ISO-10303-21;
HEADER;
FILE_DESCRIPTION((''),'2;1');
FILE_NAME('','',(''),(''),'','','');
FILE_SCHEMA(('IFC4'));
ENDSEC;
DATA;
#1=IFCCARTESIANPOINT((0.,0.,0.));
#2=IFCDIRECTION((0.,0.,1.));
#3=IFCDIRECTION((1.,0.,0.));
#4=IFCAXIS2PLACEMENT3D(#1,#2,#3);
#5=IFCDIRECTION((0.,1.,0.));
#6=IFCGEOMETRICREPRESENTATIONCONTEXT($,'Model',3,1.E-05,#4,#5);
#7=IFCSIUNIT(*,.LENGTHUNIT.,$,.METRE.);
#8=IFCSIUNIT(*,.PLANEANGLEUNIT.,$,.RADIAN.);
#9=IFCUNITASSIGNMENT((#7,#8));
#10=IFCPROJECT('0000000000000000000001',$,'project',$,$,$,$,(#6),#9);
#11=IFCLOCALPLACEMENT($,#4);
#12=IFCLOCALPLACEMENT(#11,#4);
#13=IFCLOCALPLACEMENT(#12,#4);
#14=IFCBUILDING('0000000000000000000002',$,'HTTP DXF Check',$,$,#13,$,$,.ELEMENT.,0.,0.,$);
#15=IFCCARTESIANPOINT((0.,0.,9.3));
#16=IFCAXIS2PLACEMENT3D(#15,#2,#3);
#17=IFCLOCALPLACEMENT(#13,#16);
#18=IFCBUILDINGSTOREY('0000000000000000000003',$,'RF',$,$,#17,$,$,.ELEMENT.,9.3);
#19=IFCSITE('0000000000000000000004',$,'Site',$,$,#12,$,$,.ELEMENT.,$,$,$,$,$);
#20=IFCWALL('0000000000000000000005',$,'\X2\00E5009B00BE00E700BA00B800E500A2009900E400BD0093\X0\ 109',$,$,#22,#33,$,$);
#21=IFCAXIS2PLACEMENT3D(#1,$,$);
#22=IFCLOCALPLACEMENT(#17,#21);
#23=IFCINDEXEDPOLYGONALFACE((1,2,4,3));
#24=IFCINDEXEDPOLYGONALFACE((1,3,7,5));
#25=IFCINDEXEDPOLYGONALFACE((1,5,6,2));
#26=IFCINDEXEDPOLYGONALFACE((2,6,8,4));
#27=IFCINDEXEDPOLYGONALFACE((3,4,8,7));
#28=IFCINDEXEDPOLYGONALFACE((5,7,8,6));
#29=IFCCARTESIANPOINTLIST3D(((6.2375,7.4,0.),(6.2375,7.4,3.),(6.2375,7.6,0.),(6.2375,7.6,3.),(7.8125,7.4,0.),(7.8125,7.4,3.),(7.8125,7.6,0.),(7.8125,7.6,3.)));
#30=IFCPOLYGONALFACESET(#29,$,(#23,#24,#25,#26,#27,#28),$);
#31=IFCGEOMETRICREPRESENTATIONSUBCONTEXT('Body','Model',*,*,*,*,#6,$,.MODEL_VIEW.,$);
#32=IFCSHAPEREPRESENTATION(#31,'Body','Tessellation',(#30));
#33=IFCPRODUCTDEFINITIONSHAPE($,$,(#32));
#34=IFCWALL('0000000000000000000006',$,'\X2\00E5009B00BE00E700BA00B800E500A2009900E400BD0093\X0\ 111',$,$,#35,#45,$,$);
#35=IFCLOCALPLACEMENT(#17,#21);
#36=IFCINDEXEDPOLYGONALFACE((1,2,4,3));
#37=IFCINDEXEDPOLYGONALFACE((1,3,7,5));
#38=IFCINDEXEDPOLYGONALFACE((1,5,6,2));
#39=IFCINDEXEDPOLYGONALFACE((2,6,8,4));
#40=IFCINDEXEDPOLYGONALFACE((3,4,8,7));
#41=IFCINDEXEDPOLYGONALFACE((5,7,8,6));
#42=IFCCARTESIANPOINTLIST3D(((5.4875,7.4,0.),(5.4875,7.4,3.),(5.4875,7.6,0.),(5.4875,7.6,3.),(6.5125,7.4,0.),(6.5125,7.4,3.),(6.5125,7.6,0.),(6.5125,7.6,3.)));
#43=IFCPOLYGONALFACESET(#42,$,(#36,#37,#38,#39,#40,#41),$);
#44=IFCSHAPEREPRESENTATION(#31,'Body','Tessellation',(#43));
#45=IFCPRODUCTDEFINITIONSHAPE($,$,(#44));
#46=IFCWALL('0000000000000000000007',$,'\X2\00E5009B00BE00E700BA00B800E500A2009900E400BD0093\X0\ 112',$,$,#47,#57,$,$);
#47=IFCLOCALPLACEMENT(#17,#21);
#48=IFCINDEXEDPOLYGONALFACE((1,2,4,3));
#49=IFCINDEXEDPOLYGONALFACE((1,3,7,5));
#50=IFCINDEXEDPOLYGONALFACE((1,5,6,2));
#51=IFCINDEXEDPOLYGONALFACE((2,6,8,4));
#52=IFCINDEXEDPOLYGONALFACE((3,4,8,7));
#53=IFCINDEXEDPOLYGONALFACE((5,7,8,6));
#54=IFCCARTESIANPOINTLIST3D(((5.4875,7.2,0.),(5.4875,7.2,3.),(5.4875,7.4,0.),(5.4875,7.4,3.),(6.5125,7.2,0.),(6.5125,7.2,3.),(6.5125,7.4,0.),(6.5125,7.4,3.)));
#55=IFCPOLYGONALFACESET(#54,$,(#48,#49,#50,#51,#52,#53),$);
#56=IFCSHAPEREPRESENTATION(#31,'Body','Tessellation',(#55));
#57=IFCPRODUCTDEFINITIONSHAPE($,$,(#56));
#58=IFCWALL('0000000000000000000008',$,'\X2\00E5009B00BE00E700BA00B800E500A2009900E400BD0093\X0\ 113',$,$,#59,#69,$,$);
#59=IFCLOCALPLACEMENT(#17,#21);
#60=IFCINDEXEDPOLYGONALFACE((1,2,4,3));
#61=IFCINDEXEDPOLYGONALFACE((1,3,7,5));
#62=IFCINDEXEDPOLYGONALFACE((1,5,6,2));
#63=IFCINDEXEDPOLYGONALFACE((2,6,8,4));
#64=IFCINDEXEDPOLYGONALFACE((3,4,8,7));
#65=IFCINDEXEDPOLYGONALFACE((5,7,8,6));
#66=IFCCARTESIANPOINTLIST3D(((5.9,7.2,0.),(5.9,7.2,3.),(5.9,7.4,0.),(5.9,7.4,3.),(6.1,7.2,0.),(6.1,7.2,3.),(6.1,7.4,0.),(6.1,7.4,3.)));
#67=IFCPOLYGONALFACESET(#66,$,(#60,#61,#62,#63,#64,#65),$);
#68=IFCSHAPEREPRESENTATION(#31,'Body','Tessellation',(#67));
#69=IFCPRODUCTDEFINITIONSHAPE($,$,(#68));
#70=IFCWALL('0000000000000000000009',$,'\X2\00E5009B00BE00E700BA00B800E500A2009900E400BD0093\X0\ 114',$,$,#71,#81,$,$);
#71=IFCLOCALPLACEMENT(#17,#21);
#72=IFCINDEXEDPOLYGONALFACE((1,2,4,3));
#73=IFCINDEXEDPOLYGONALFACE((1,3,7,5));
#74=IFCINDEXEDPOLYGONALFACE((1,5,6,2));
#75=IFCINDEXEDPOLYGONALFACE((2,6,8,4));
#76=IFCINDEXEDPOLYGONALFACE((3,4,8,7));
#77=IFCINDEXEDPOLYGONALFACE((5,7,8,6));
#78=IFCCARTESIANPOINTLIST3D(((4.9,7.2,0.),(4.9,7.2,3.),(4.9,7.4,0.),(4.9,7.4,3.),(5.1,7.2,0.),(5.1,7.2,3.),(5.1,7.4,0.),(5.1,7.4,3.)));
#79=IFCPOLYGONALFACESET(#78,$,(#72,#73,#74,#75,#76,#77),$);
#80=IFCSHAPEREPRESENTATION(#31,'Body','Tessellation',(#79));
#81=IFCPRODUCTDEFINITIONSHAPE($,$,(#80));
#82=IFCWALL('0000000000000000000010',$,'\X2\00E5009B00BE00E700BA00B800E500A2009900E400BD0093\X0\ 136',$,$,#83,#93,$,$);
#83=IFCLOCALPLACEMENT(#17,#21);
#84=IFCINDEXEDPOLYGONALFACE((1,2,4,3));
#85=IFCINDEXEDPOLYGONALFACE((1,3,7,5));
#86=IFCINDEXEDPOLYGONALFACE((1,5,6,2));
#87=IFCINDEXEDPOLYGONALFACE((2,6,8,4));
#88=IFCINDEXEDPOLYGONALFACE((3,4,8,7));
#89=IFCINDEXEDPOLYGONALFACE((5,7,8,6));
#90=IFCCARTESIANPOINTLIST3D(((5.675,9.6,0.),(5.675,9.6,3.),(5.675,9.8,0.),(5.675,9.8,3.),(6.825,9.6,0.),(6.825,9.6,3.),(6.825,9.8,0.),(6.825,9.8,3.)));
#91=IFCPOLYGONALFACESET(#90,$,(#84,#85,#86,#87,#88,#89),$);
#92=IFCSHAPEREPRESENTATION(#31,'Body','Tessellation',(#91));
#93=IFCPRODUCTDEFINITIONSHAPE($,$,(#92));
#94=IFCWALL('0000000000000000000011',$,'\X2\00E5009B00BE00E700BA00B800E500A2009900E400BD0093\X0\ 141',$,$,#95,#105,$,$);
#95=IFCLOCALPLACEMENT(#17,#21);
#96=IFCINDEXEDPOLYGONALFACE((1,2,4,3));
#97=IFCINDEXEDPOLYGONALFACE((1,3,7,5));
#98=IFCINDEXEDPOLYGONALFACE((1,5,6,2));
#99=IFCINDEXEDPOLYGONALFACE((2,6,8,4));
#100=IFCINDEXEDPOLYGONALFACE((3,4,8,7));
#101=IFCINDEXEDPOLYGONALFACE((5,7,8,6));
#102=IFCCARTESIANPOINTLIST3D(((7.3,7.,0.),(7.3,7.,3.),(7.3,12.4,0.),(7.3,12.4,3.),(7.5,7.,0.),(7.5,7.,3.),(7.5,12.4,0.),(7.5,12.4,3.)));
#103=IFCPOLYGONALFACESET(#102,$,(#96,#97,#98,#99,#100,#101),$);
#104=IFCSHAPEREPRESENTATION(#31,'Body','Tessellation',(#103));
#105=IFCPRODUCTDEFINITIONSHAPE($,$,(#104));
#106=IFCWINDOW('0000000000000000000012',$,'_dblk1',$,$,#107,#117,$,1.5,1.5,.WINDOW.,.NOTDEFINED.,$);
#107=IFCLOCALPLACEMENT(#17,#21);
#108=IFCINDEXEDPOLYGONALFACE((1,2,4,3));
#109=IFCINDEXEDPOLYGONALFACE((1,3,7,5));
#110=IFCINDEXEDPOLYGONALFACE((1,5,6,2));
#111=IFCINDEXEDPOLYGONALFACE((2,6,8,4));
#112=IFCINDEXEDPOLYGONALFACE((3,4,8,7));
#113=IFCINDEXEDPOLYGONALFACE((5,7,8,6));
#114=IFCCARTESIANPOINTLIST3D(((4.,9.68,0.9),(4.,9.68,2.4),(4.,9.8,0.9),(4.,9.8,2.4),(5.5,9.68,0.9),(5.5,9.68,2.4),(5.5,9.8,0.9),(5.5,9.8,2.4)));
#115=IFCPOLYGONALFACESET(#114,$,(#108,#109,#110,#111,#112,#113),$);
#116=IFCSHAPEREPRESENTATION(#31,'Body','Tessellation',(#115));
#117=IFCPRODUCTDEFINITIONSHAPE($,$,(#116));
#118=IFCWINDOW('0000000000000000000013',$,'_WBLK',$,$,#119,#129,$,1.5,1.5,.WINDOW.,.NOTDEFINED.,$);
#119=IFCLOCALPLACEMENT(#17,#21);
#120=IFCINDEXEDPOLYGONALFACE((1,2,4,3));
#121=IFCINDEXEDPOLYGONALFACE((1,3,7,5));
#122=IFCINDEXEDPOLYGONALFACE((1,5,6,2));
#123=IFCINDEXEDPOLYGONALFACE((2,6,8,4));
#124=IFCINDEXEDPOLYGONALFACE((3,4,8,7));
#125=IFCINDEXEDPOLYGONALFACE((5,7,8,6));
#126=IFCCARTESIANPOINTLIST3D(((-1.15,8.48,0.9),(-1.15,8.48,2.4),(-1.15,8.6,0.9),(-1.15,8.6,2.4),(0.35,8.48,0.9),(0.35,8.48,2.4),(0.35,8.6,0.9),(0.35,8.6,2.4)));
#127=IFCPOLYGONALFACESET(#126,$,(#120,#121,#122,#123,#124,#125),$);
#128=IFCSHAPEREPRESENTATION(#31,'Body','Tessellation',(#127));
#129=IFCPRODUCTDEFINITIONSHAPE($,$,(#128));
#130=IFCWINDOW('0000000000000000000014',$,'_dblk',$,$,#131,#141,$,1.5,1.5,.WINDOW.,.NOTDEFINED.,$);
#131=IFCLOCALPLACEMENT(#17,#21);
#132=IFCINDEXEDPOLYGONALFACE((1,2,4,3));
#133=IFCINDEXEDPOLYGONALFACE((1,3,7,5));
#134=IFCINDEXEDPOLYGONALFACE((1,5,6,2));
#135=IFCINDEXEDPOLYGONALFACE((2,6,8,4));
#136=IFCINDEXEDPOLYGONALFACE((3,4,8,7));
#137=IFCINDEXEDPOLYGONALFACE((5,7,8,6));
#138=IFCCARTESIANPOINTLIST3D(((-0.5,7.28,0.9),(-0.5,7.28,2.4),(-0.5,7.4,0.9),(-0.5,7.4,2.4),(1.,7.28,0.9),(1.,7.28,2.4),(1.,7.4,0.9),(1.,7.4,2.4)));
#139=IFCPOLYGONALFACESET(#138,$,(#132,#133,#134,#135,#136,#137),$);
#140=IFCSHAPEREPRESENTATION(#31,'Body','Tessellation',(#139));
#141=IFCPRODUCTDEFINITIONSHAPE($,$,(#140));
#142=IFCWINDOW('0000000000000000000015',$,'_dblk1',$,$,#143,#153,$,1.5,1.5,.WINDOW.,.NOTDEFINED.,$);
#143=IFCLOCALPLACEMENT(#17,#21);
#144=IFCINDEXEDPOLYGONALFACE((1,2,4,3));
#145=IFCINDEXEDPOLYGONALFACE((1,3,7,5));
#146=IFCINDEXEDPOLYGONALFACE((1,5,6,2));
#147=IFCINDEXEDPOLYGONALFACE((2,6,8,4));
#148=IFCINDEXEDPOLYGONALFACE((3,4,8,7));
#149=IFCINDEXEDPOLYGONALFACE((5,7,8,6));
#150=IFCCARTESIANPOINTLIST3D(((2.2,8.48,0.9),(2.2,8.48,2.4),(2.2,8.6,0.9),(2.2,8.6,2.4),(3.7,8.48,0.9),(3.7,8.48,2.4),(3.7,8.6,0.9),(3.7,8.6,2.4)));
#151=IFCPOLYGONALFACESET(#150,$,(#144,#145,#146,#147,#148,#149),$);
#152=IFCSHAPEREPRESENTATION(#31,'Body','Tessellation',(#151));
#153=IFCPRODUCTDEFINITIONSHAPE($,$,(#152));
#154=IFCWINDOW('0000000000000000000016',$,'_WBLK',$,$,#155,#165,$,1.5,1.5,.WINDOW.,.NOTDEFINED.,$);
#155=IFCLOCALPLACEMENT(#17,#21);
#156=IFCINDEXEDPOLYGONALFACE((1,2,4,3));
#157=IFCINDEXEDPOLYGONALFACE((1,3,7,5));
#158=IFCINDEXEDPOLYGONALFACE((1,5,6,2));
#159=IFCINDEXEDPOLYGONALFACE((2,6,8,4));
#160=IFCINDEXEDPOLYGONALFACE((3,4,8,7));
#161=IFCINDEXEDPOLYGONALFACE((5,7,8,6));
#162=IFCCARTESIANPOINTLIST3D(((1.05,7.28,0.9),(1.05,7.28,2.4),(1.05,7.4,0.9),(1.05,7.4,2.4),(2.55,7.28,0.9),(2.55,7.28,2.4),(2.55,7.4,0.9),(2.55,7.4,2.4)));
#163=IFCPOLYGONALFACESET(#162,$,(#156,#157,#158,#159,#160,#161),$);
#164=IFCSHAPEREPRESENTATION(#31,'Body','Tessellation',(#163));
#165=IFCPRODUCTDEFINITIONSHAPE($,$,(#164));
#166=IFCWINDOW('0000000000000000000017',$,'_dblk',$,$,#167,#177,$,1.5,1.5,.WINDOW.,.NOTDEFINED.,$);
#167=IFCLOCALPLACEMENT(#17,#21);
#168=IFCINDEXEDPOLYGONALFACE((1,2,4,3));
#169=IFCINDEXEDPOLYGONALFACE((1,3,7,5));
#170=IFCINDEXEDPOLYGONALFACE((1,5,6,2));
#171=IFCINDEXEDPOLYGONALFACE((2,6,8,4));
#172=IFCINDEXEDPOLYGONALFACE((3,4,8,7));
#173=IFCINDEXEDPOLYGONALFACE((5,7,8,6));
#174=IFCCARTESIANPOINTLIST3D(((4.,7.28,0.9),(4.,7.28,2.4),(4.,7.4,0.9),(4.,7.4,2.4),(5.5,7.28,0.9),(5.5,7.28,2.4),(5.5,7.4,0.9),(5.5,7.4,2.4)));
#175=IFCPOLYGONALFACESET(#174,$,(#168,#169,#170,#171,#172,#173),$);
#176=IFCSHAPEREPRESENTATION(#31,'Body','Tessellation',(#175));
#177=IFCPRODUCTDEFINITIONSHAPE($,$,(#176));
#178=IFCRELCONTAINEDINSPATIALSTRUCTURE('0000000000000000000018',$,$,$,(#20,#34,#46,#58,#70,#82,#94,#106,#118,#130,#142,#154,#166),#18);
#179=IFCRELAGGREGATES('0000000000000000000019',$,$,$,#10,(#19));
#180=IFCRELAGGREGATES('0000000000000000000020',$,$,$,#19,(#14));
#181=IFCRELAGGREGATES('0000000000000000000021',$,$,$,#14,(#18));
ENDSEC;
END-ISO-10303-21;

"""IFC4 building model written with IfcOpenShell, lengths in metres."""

from ifc_helpers import new_model, si_unit, direction, frame, frame_2d, origin_with_axes, place, context, subcontext, project, spatial, rectangle, extrude, element, save


model = new_model("IFC4")

# Units and contexts
model_context = context("Model", 3, precision=1e-05, world=origin_with_axes(), true_north=direction((0.0, 1.0, 0.0)))
body_context = subcontext(model_context, "Body", "Model", "MODEL_VIEW")
ifc_project = project(units=[si_unit("LENGTHUNIT", "METRE"), si_unit("PLANEANGLEUNIT", "RADIAN")], contexts=[model_context])

# Site, building, storey
placement = place(None, origin_with_axes())
site_placement = place(placement, origin_with_axes())
site = spatial("IfcSite", under=ifc_project, at=site_placement, Name="Site", CompositionType="ELEMENT")
building_placement = place(site_placement, origin_with_axes())
building = spatial("IfcBuilding", under=site, at=building_placement, Name="HTTP DXF Check", CompositionType="ELEMENT", ElevationOfRefHeight=0.0, ElevationOfTerrain=0.0)
storey_placement = place(building_placement, frame((0.0, 0.0, 9.3), z_axis=(0.0, 0.0, 1.0), x_axis=(1.0, 0.0, 0.0)))
storey = spatial("IfcBuildingStorey", under=building, at=storey_placement, Name="RF", CompositionType="ELEMENT", Elevation=9.3)

# Walls
wall_1_placement = place(storey_placement, frame((7.025, 7.5, 0.0), z_axis=(0.0, 0.0, 1.0), x_axis=(1.0, 0.0, 0.0)))
element("IfcWall", 1, at=wall_1_placement, inside=storey, Name="å\u009b¾çº¸å¢\u0099ä½\u0093 109", context=body_context, shape_type="SweptSolid", body=[
    extrude(rectangle(XDim=1.575, YDim=0.2, at=frame_2d((0.0, 0.0), x_axis=(1.0, 0.0, 0.0))), frame((0.0, 0.0, 0.0), z_axis=(0.0, 0.0, 1.0)), (0.0, 0.0, 1.0), 3.0),
])
for number, where, z_axis, x_axis, name in (
    (2, (6.0, 7.5, 0.0), (0.0, 0.0, 1.0), (1.0, 0.0, 0.0), "å\u009b¾çº¸å¢\u0099ä½\u0093 111"),
    (3, (6.0, 7.3, 0.0), (0.0, 0.0, 1.0), (1.0, 0.0, 0.0), "å\u009b¾çº¸å¢\u0099ä½\u0093 112"),
):
    element("IfcWall", number, at=place(storey_placement, frame(where, z_axis=z_axis, x_axis=x_axis)), inside=storey, Name=name, context=body_context, shape_type="SweptSolid", body=[
        extrude(rectangle(XDim=1.025, YDim=0.2, at=frame_2d((0.0, 0.0), x_axis=(1.0, 0.0, 0.0))), frame((0.0, 0.0, 0.0), z_axis=(0.0, 0.0, 1.0)), (0.0, 0.0, 1.0), 3.0),
    ])
for number, where, z_axis, x_axis, name in (
    (4, (6.0, 7.3, 0.0), (0.0, 0.0, 1.0), (0.0, 1.0, 0.0), "å\u009b¾çº¸å¢\u0099ä½\u0093 113"),
    (5, (5.0, 7.3, 0.0), (0.0, 0.0, 1.0), (0.0, 1.0, 0.0), "å\u009b¾çº¸å¢\u0099ä½\u0093 114"),
):
    element("IfcWall", number, at=place(storey_placement, frame(where, z_axis=z_axis, x_axis=x_axis)), inside=storey, Name=name, context=body_context, shape_type="SweptSolid", body=[
        extrude(rectangle(XDim=0.2, YDim=0.2, at=frame_2d((0.0, 0.0), x_axis=(1.0, 0.0, 0.0))), frame((0.0, 0.0, 0.0), z_axis=(0.0, 0.0, 1.0)), (0.0, 0.0, 1.0), 3.0),
    ])
wall_2_placement = place(storey_placement, frame((6.25, 9.7, 0.0), z_axis=(0.0, 0.0, 1.0), x_axis=(1.0, 0.0, 0.0)))
element("IfcWall", 6, at=wall_2_placement, inside=storey, Name="å\u009b¾çº¸å¢\u0099ä½\u0093 136", context=body_context, shape_type="SweptSolid", body=[
    extrude(rectangle(XDim=1.15, YDim=0.2, at=frame_2d((0.0, 0.0), x_axis=(1.0, 0.0, 0.0))), frame((0.0, 0.0, 0.0), z_axis=(0.0, 0.0, 1.0)), (0.0, 0.0, 1.0), 3.0),
])
wall_3_placement = place(storey_placement, frame((7.4, 9.7, 0.0), z_axis=(0.0, 0.0, 1.0), x_axis=(0.0, 1.0, 0.0)))
element("IfcWall", 7, at=wall_3_placement, inside=storey, Name="å\u009b¾çº¸å¢\u0099ä½\u0093 141", context=body_context, shape_type="SweptSolid", body=[
    extrude(rectangle(XDim=5.4, YDim=0.2, at=frame_2d((0.0, 0.0), x_axis=(1.0, 0.0, 0.0))), frame((0.0, 0.0, 0.0), z_axis=(0.0, 0.0, 1.0)), (0.0, 0.0, 1.0), 3.0),
])

# Windows
for number, where, z_axis, x_axis, name in (
    (8, (4.75, 9.74, 0.9), (0.0, 0.0, 1.0), (1.0, 0.0, 0.0), "_dblk1"),
    (9, (-0.4, 8.54, 0.9), (0.0, 0.0, 1.0), (1.0, 0.0, 0.0), "_WBLK"),
    (10, (0.25, 7.34, 0.9), (0.0, 0.0, 1.0), (1.0, 0.0, 0.0), "_dblk"),
    (11, (2.95, 8.54, 0.9), (0.0, 0.0, 1.0), (1.0, 0.0, 0.0), "_dblk1"),
    (12, (1.8, 7.34, 0.9), (0.0, 0.0, 1.0), (1.0, 0.0, 0.0), "_WBLK"),
    (13, (4.75, 7.34, 0.9), (0.0, 0.0, 1.0), (1.0, 0.0, 0.0), "_dblk"),
):
    element("IfcWindow", number, at=place(storey_placement, frame(where, z_axis=z_axis, x_axis=x_axis)), inside=storey, Name=name, OverallHeight=1.5, OverallWidth=1.5, PartitioningType="NOTDEFINED", PredefinedType="WINDOW", context=body_context, shape_type="SweptSolid", body=[
        extrude(rectangle(XDim=1.5, YDim=0.12, at=frame_2d((0.0, 0.0), x_axis=(1.0, 0.0, 0.0))), frame((0.0, 0.0, 0.0), z_axis=(0.0, 0.0, 1.0)), (0.0, 0.0, 1.0), 1.5),
    ])

save(model, "model.ifc")
